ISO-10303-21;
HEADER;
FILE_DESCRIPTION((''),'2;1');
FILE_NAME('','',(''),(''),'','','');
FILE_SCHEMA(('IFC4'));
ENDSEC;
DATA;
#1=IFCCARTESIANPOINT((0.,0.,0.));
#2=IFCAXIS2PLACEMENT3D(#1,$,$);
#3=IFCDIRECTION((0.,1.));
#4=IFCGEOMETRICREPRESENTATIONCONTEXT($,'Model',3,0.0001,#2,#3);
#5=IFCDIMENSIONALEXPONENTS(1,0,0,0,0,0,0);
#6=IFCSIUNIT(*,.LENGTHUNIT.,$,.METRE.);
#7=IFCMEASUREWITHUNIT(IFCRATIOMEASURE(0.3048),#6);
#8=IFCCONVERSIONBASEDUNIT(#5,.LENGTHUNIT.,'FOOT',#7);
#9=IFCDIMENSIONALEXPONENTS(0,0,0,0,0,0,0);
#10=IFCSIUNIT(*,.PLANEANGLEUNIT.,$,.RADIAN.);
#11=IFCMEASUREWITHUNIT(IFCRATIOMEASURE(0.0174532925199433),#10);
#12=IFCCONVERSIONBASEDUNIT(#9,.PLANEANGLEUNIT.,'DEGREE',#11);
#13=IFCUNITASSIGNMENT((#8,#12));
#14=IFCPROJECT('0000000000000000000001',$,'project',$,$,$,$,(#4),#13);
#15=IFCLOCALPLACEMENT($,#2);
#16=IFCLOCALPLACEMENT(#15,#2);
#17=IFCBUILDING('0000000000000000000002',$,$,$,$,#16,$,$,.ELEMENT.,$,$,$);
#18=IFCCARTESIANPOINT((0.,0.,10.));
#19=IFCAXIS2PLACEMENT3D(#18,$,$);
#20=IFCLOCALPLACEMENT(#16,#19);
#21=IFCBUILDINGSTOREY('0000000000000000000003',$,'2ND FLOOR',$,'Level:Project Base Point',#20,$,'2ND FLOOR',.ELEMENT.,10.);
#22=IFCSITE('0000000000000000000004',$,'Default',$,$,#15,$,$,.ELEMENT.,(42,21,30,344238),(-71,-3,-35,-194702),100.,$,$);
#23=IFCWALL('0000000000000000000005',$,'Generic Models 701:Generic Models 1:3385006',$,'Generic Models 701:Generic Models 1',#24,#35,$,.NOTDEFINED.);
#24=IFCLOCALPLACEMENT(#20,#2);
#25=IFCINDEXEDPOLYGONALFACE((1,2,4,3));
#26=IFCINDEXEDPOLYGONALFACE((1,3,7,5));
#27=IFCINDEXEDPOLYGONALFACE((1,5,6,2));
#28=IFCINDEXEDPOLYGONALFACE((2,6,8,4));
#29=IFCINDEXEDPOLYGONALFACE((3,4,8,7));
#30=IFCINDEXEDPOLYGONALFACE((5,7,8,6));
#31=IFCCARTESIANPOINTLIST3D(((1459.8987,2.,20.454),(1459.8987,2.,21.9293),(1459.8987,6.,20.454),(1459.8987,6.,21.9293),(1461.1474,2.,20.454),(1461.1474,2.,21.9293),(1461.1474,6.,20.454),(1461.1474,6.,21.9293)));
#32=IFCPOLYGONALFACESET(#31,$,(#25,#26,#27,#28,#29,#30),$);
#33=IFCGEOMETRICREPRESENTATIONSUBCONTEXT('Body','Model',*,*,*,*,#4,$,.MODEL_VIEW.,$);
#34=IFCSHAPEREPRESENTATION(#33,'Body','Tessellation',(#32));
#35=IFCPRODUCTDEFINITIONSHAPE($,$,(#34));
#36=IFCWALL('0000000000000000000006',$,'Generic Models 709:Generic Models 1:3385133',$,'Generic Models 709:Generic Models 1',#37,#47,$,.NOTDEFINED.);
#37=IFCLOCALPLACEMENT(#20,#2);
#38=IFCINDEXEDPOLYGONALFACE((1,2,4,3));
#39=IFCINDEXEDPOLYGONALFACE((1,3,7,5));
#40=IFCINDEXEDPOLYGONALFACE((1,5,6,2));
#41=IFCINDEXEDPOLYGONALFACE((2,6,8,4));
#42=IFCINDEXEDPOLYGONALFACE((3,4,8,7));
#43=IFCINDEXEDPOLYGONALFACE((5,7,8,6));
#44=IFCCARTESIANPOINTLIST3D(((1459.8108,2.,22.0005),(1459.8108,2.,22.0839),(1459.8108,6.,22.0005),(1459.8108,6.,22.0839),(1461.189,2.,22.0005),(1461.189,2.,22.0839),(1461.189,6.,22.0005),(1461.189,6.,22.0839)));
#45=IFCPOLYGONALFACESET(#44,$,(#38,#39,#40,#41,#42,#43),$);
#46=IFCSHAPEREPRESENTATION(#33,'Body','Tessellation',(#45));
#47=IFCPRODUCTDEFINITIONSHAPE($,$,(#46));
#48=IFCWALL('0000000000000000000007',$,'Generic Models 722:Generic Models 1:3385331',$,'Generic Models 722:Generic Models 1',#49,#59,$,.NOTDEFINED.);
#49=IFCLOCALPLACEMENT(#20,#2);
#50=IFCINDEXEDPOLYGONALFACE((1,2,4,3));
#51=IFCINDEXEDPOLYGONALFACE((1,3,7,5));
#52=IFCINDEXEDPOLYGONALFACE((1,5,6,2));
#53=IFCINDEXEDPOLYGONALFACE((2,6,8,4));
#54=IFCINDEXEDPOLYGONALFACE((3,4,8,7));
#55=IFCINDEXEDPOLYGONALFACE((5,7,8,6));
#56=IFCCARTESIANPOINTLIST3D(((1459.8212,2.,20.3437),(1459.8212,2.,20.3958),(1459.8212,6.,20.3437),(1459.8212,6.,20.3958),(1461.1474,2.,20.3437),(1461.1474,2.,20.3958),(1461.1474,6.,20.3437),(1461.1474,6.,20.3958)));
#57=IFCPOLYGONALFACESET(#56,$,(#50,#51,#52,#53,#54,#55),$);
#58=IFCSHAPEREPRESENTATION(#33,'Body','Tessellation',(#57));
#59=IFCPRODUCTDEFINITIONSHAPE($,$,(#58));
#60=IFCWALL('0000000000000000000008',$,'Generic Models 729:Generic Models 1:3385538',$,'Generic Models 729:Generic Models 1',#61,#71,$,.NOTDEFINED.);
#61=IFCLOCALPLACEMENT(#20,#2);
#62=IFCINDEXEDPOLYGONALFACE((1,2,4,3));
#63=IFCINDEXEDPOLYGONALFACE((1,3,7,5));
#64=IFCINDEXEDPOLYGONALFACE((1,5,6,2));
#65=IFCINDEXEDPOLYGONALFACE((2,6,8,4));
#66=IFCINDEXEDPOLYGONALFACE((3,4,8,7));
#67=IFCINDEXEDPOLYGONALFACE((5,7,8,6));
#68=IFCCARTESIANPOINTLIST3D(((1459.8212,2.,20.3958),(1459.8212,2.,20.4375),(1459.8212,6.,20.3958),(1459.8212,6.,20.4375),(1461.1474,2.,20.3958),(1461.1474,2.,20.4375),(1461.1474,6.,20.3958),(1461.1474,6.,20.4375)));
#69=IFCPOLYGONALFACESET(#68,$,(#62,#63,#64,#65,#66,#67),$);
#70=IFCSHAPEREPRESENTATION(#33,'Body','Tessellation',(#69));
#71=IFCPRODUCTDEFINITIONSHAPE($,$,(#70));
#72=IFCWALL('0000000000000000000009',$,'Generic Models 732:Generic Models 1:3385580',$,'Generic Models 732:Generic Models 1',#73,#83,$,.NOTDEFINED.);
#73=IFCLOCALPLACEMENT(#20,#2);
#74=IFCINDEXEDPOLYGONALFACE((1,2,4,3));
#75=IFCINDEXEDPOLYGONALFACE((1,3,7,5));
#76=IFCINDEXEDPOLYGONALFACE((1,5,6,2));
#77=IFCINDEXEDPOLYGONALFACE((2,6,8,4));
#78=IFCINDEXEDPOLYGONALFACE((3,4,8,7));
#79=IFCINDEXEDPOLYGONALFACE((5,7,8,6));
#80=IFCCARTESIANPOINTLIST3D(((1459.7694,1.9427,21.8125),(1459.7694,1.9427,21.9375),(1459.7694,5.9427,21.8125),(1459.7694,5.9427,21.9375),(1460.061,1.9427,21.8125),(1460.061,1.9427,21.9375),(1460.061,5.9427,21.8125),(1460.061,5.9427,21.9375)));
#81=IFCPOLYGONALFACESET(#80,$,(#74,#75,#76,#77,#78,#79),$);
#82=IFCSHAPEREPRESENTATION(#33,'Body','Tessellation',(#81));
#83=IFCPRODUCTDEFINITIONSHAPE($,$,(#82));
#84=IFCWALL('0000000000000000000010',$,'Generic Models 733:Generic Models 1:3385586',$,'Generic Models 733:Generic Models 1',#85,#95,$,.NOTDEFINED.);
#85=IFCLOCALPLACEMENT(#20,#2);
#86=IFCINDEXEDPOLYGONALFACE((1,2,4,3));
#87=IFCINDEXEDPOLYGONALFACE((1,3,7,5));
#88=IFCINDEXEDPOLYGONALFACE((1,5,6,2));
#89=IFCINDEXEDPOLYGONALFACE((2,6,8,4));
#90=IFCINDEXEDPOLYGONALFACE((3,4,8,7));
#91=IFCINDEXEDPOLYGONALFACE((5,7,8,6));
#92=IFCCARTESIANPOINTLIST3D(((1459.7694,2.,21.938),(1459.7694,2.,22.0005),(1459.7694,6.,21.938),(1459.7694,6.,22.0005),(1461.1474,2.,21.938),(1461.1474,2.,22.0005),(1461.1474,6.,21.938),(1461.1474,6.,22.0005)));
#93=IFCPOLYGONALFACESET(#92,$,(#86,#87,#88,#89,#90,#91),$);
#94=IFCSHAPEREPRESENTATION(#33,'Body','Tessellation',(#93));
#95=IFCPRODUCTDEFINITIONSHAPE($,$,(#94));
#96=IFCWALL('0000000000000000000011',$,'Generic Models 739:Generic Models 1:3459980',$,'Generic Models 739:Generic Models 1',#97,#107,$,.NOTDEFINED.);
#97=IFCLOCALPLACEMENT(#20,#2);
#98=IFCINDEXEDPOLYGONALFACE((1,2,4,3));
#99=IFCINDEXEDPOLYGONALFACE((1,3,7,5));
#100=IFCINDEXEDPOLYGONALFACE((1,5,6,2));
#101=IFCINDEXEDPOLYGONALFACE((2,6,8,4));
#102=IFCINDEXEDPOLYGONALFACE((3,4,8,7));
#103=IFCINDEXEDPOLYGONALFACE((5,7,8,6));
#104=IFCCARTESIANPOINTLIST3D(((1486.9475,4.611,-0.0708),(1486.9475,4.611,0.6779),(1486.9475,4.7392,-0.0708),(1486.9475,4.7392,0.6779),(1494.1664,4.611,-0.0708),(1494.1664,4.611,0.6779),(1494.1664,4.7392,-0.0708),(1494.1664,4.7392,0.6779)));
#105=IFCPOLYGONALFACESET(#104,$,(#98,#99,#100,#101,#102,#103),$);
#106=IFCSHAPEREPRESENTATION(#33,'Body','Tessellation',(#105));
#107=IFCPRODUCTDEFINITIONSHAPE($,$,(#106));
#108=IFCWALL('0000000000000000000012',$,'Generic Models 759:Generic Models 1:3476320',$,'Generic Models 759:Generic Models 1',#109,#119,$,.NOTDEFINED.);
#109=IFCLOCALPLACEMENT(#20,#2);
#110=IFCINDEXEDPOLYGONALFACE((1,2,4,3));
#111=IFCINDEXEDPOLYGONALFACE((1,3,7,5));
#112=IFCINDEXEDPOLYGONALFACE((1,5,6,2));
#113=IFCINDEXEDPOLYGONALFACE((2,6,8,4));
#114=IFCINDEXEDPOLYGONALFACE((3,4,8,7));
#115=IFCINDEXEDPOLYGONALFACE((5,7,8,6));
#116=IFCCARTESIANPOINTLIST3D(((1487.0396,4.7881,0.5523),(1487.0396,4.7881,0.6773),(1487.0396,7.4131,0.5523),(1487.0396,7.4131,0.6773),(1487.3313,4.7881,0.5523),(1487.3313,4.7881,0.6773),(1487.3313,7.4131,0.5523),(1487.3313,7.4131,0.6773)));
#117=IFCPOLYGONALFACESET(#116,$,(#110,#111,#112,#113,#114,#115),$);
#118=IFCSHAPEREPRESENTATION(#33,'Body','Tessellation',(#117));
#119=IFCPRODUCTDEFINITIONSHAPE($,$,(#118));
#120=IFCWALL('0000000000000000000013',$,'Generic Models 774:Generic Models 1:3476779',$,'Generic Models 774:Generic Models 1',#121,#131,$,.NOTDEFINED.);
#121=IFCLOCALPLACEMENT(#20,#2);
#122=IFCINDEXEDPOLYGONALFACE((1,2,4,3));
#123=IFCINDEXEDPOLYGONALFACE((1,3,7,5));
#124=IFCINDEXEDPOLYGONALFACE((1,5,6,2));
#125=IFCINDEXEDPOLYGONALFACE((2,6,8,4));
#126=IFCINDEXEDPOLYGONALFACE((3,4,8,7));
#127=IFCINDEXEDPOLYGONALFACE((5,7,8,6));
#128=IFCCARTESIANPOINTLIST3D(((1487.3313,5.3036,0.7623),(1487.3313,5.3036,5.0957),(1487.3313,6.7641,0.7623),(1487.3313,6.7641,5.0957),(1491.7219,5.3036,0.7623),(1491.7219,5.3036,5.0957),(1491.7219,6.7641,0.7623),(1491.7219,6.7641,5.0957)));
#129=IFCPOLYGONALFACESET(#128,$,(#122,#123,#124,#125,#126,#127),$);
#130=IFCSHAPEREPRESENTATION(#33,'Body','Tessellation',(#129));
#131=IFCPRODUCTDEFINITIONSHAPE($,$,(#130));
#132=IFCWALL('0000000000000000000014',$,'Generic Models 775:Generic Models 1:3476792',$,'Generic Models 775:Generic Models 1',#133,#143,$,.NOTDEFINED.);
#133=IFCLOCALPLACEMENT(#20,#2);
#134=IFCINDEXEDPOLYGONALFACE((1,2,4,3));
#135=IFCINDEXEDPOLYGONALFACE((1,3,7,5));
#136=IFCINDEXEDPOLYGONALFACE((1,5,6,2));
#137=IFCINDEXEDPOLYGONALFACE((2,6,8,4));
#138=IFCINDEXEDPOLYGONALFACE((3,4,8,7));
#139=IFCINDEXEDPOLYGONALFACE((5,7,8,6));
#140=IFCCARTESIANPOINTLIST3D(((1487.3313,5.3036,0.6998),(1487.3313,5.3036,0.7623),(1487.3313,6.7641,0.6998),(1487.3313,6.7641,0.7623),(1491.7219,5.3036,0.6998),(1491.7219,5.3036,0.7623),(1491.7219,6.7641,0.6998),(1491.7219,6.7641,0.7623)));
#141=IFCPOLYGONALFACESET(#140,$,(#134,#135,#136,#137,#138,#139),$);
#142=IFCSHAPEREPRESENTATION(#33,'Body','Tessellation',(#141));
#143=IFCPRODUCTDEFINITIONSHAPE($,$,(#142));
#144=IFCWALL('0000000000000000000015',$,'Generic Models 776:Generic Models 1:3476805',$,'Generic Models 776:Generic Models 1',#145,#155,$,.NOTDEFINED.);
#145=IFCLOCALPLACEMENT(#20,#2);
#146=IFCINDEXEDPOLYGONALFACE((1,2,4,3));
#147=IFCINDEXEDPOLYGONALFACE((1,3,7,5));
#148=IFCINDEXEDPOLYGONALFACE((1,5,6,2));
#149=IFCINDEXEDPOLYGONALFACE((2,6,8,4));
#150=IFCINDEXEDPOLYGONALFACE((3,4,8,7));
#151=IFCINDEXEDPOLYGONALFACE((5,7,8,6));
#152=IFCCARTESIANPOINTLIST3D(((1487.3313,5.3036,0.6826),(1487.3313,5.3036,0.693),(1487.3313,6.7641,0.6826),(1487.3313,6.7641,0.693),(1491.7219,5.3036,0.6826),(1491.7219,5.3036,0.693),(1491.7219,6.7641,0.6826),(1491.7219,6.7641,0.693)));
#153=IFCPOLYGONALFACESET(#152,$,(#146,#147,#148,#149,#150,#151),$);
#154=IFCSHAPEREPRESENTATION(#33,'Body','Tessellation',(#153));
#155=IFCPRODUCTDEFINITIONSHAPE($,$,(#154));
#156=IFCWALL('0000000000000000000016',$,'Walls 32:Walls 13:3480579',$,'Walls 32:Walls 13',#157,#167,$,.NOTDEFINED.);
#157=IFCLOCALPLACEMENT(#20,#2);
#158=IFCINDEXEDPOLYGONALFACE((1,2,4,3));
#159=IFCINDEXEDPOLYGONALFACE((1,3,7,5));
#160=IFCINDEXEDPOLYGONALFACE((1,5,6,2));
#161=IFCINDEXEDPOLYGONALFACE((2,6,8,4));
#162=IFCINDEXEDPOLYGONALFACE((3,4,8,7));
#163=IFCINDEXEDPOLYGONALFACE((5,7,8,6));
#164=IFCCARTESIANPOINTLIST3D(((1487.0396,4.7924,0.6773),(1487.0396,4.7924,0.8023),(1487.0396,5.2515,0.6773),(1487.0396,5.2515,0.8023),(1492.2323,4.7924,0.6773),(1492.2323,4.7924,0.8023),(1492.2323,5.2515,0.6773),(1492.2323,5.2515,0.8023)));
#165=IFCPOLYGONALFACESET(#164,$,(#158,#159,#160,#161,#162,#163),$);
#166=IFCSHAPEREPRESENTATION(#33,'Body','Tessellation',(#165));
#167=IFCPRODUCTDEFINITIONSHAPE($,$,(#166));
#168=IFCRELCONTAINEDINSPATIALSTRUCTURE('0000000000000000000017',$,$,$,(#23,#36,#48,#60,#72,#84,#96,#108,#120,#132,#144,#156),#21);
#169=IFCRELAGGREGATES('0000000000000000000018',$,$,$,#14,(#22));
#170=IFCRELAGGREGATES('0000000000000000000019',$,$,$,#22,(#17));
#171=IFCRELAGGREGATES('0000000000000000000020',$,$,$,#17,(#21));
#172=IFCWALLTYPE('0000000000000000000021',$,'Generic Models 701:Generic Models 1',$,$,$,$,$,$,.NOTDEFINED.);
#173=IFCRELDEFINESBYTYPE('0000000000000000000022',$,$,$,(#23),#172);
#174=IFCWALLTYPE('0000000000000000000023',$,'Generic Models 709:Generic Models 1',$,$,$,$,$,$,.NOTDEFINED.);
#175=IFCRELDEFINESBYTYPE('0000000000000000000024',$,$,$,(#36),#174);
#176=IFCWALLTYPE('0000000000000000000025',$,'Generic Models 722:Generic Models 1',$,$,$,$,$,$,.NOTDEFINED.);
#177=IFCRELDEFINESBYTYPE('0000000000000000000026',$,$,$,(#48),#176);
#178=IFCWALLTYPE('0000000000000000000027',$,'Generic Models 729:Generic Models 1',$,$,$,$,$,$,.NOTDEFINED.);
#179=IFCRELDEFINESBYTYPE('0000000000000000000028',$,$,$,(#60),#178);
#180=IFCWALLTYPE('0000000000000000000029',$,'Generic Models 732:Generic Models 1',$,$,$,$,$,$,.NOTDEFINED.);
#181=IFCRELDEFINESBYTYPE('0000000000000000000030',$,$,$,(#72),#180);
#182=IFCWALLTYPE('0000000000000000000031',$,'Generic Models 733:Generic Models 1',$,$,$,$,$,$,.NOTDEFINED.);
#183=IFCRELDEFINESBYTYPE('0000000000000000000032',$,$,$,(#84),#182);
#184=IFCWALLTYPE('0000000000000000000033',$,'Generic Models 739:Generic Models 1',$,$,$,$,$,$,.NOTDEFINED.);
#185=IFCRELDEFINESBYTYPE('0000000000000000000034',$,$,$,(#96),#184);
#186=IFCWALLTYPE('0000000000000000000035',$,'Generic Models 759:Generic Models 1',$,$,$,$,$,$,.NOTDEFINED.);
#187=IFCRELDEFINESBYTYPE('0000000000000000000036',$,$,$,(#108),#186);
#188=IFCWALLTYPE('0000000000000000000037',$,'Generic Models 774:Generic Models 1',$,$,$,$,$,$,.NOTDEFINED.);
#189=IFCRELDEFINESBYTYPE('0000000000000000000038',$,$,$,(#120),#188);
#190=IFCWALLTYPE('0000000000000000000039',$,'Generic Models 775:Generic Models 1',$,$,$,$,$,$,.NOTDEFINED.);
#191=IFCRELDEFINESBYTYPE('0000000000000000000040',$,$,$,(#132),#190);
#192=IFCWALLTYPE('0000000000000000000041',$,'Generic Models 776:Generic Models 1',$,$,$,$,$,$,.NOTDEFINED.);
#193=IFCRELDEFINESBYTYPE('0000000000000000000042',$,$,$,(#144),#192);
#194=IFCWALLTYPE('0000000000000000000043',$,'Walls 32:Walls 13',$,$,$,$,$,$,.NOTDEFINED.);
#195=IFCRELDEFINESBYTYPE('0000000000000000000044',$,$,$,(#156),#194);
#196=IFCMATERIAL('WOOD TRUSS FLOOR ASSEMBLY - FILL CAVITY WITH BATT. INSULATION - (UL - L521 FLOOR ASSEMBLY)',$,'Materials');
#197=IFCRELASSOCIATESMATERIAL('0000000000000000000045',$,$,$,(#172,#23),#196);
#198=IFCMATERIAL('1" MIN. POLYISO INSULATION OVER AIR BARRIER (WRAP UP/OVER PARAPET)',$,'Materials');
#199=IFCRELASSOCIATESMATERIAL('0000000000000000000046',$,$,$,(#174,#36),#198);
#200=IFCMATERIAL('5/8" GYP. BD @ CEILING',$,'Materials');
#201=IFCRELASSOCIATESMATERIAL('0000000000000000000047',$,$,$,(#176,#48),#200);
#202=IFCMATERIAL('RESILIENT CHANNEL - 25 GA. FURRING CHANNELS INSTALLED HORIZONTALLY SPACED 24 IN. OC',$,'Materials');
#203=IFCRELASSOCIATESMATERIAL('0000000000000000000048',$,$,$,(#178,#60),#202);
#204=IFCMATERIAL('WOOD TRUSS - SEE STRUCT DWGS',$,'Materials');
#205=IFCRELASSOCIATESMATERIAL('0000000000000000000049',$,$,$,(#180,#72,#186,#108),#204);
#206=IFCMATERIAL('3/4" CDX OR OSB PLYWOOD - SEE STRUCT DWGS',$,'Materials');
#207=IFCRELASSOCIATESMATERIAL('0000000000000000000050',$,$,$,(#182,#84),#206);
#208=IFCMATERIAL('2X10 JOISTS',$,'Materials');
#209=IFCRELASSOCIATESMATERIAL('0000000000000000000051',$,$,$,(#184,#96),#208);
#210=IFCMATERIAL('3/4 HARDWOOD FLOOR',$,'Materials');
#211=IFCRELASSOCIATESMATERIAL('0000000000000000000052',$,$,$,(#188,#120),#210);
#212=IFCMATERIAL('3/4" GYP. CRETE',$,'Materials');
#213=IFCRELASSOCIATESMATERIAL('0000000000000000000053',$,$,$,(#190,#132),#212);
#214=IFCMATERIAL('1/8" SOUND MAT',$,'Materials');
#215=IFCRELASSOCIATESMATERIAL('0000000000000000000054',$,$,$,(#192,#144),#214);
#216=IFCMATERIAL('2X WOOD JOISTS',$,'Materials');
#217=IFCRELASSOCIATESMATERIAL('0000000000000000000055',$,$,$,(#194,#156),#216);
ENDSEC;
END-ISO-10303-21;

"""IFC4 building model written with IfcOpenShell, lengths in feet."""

from ifc_helpers import new_model, entity, si_unit, converted_unit, direction, frame, frame_2d, origin, origin_2d_with_axis, place, context, subcontext, project, spatial, rectangle, extrude, material, type_object, element, save


model = new_model("IFC4")

# Units and contexts
model_context = context("Model", 3, precision=0.0001, world=origin(), true_north=direction((0.0, 1.0)))
body_context = subcontext(model_context, "Body", "Model", "MODEL_VIEW")
ifc_project = project(units=[converted_unit("LENGTHUNIT", "FOOT", entity("IfcRatioMeasure", 0.3048), si_unit("LENGTHUNIT", "METRE"), dimensions=[1, 0, 0, 0, 0, 0, 0]), converted_unit("PLANEANGLEUNIT", "DEGREE", entity("IfcRatioMeasure", 0.0174532925199433), si_unit("PLANEANGLEUNIT", "RADIAN"), dimensions=[0, 0, 0, 0, 0, 0, 0])], contexts=[model_context])

# Site, building, storey
site_placement = place(None, origin())
site = spatial("IfcSite", under=ifc_project, at=site_placement, Name="Default", CompositionType="ELEMENT", RefLatitude=(42, 21, 30, 344238), RefLongitude=(-71, -3, -35, -194702), RefElevation=100.0)
building_placement = place(site_placement, origin())
building = spatial("IfcBuilding", under=site, at=building_placement, CompositionType="ELEMENT")
storey_placement = place(building_placement, frame((0.0, 0.0, 10.0)))
storey = spatial("IfcBuildingStorey", under=building, at=storey_placement, Name="2ND FLOOR", ObjectType="Level:Project Base Point", LongName="2ND FLOOR", CompositionType="ELEMENT", Elevation=10.0)

# Walls
ifc_material_1 = material(Name="WOOD TRUSS FLOOR ASSEMBLY - FILL CAVITY WITH BATT. INSULATION - (UL - L521 FLOOR ASSEMBLY)", Category="Materials")
wall_type_1 = type_object("IfcWallType", Name="Generic Models 701:Generic Models 1", PredefinedType="NOTDEFINED", material=ifc_material_1)
wall_1_placement = place(storey_placement, frame((1459.8987, 2.0, 20.454), z_axis=(0.0, 0.0, 1.0), x_axis=(0.0, 1.0, 0.0)))
element("IfcWall", 1, at=wall_1_placement, inside=storey, type_object=wall_type_1, material=ifc_material_1, Name="Generic Models 701:Generic Models 1:3385006", ObjectType="Generic Models 701:Generic Models 1", PredefinedType="NOTDEFINED", context=body_context, shape_type="SweptSolid", body=[
    extrude(rectangle(XDim=4.0, YDim=1.2486, at=frame_2d((0.0, 0.0), x_axis=(1.0, 0.0))), frame((2.0, -0.6243, 0.0)), (0.0, 0.0, 1.0), 1.4753),
])
ifc_material_2 = material(Name="1\" MIN. POLYISO INSULATION OVER AIR BARRIER (WRAP UP/OVER PARAPET)", Category="Materials")
wall_type_2 = type_object("IfcWallType", Name="Generic Models 709:Generic Models 1", PredefinedType="NOTDEFINED", material=ifc_material_2)
wall_2_placement = place(storey_placement, frame((1459.8108, 2.0, 22.0005), z_axis=(0.0, 0.0, 1.0), x_axis=(0.0, 1.0, 0.0)))
element("IfcWall", 2, at=wall_2_placement, inside=storey, type_object=wall_type_2, material=ifc_material_2, Name="Generic Models 709:Generic Models 1:3385133", ObjectType="Generic Models 709:Generic Models 1", PredefinedType="NOTDEFINED", context=body_context, shape_type="SweptSolid", body=[
    extrude(rectangle(XDim=4.0, YDim=1.3782, at=frame_2d((0.0, 0.0), x_axis=(1.0, 0.0))), frame((2.0, -0.6891, 0.0)), (0.0, 0.0, 1.0), 0.0833),
])
ifc_material_3 = material(Name="5/8\" GYP. BD @ CEILING", Category="Materials")
wall_type_3 = type_object("IfcWallType", Name="Generic Models 722:Generic Models 1", PredefinedType="NOTDEFINED", material=ifc_material_3)
wall_3_placement = place(storey_placement, frame((1459.8212, 2.0, 20.3437), z_axis=(0.0, 0.0, 1.0), x_axis=(0.0, 1.0, 0.0)))
element("IfcWall", 3, at=wall_3_placement, inside=storey, type_object=wall_type_3, material=ifc_material_3, Name="Generic Models 722:Generic Models 1:3385331", ObjectType="Generic Models 722:Generic Models 1", PredefinedType="NOTDEFINED", context=body_context, shape_type="SweptSolid", body=[
    extrude(rectangle(XDim=4.0, YDim=1.3261, at=frame_2d((0.0, 0.0), x_axis=(1.0, 0.0))), frame((2.0, -0.6631, 0.0)), (0.0, 0.0, 1.0), 0.0521),
])
ifc_material_4 = material(Name="RESILIENT CHANNEL - 25 GA. FURRING CHANNELS INSTALLED HORIZONTALLY SPACED 24 IN. OC", Category="Materials")
wall_type_4 = type_object("IfcWallType", Name="Generic Models 729:Generic Models 1", PredefinedType="NOTDEFINED", material=ifc_material_4)
wall_4_placement = place(storey_placement, frame((1459.8212, 2.0, 20.3958), z_axis=(0.0, 0.0, 1.0), x_axis=(0.0, 1.0, 0.0)))
element("IfcWall", 4, at=wall_4_placement, inside=storey, type_object=wall_type_4, material=ifc_material_4, Name="Generic Models 729:Generic Models 1:3385538", ObjectType="Generic Models 729:Generic Models 1", PredefinedType="NOTDEFINED", context=body_context, shape_type="SweptSolid", body=[
    extrude(rectangle(XDim=4.0, YDim=1.3261, at=frame_2d((0.0, 0.0), x_axis=(1.0, 0.0))), frame((2.0, -0.6631, 0.0)), (0.0, 0.0, 1.0), 0.0417),
])
ifc_material_5 = material(Name="WOOD TRUSS - SEE STRUCT DWGS", Category="Materials")
wall_type_5 = type_object("IfcWallType", Name="Generic Models 732:Generic Models 1", PredefinedType="NOTDEFINED", material=ifc_material_5)
wall_5_placement = place(storey_placement, frame((1459.7694, 1.9427, 21.8125), z_axis=(0.0, 0.0, 1.0), x_axis=(0.0, 1.0, 0.0)))
element("IfcWall", 5, at=wall_5_placement, inside=storey, type_object=wall_type_5, material=ifc_material_5, Name="Generic Models 732:Generic Models 1:3385580", ObjectType="Generic Models 732:Generic Models 1", PredefinedType="NOTDEFINED", context=body_context, shape_type="SweptSolid", body=[
    extrude(rectangle(XDim=4.0, YDim=0.2917, at=frame_2d((0.0, 0.0), x_axis=(1.0, 0.0))), frame((2.0, -0.1458, 0.0)), (0.0, 0.0, 1.0), 0.125),
])
ifc_material_6 = material(Name="3/4\" CDX OR OSB PLYWOOD - SEE STRUCT DWGS", Category="Materials")
wall_type_6 = type_object("IfcWallType", Name="Generic Models 733:Generic Models 1", PredefinedType="NOTDEFINED", material=ifc_material_6)
wall_6_placement = place(storey_placement, frame((1459.7694, 2.0, 21.938), z_axis=(0.0, 0.0, 1.0), x_axis=(0.0, 1.0, 0.0)))
element("IfcWall", 6, at=wall_6_placement, inside=storey, type_object=wall_type_6, material=ifc_material_6, Name="Generic Models 733:Generic Models 1:3385586", ObjectType="Generic Models 733:Generic Models 1", PredefinedType="NOTDEFINED", context=body_context, shape_type="SweptSolid", body=[
    extrude(rectangle(XDim=4.0, YDim=1.378, at=frame_2d((0.0, 0.0), x_axis=(1.0, 0.0))), frame((2.0, -0.689, 0.0)), (0.0, 0.0, 1.0), 0.0625),
])
ifc_material_7 = material(Name="2X10 JOISTS", Category="Materials")
wall_type_7 = type_object("IfcWallType", Name="Generic Models 739:Generic Models 1", PredefinedType="NOTDEFINED", material=ifc_material_7)
wall_7_placement = place(storey_placement, frame((1486.9475, 4.611, -0.0708)))
element("IfcWall", 7, at=wall_7_placement, inside=storey, type_object=wall_type_7, material=ifc_material_7, Name="Generic Models 739:Generic Models 1:3459980", ObjectType="Generic Models 739:Generic Models 1", PredefinedType="NOTDEFINED", context=body_context, shape_type="SweptSolid", body=[
    extrude(rectangle(XDim=0.1282, YDim=7.219, at=frame_2d((0.0, 0.0), x_axis=(1.0, 0.0))), frame((3.6095, 0.0641, 0.0), z_axis=(0.0, 0.0, 1.0), x_axis=(0.0, 1.0, 0.0)), (0.0, 0.0, 1.0), 0.7486),
])
wall_type_8 = type_object("IfcWallType", Name="Generic Models 759:Generic Models 1", PredefinedType="NOTDEFINED", material=ifc_material_5)
wall_8_placement = place(storey_placement, frame((1487.0396, 4.7881, 0.5523), z_axis=(0.0, 0.0, 1.0), x_axis=(0.0, 1.0, 0.0)))
element("IfcWall", 8, at=wall_8_placement, inside=storey, type_object=wall_type_8, material=ifc_material_5, Name="Generic Models 759:Generic Models 1:3476320", ObjectType="Generic Models 759:Generic Models 1", PredefinedType="NOTDEFINED", context=body_context, shape_type="SweptSolid", body=[
    extrude(rectangle(XDim=2.625, YDim=0.2917, at=frame_2d((0.0, 0.0), x_axis=(1.0, 0.0))), frame((1.3125, -0.1458, 0.0)), (0.0, 0.0, 1.0), 0.125),
])
ifc_material_8 = material(Name="3/4 HARDWOOD FLOOR", Category="Materials")
wall_type_9 = type_object("IfcWallType", Name="Generic Models 774:Generic Models 1", PredefinedType="NOTDEFINED", material=ifc_material_8)
wall_9_placement = place(storey_placement, frame((1487.3313, 5.3036, 0.7623)))
element("IfcWall", 9, at=wall_9_placement, inside=storey, type_object=wall_type_9, material=ifc_material_8, Name="Generic Models 774:Generic Models 1:3476779", ObjectType="Generic Models 774:Generic Models 1", PredefinedType="NOTDEFINED", context=body_context, shape_type="SweptSolid", body=[
    extrude(rectangle(XDim=1.4605, YDim=4.3906, at=frame_2d((0.0, 0.0), x_axis=(1.0, 0.0))), frame((2.1953, 0.7302, 0.0), z_axis=(0.0, 0.0, 1.0), x_axis=(0.0, 1.0, 0.0)), (0.0, 0.0, 1.0), 4.3334),
])
ifc_material_9 = material(Name="3/4\" GYP. CRETE", Category="Materials")
wall_type_10 = type_object("IfcWallType", Name="Generic Models 775:Generic Models 1", PredefinedType="NOTDEFINED", material=ifc_material_9)
wall_10_placement = place(storey_placement, frame((1487.3313, 5.3036, 0.6998)))
element("IfcWall", 10, at=wall_10_placement, inside=storey, type_object=wall_type_10, material=ifc_material_9, Name="Generic Models 775:Generic Models 1:3476792", ObjectType="Generic Models 775:Generic Models 1", PredefinedType="NOTDEFINED", context=body_context, shape_type="SweptSolid", body=[
    extrude(rectangle(XDim=1.4605, YDim=4.3906, at=frame_2d((0.0, 0.0), x_axis=(1.0, 0.0))), frame((2.1953, 0.7302, 0.0), z_axis=(0.0, 0.0, 1.0), x_axis=(0.0, 1.0, 0.0)), (0.0, 0.0, 1.0), 0.0625),
])
ifc_material_10 = material(Name="1/8\" SOUND MAT", Category="Materials")
wall_type_11 = type_object("IfcWallType", Name="Generic Models 776:Generic Models 1", PredefinedType="NOTDEFINED", material=ifc_material_10)
wall_11_placement = place(storey_placement, frame((1487.3313, 5.3036, 0.6826)))
element("IfcWall", 11, at=wall_11_placement, inside=storey, type_object=wall_type_11, material=ifc_material_10, Name="Generic Models 776:Generic Models 1:3476805", ObjectType="Generic Models 776:Generic Models 1", PredefinedType="NOTDEFINED", context=body_context, shape_type="SweptSolid", body=[
    extrude(rectangle(XDim=1.4605, YDim=4.3906, at=frame_2d((0.0, 0.0), x_axis=(1.0, 0.0))), frame((2.1953, 0.7302, 0.0), z_axis=(0.0, 0.0, 1.0), x_axis=(0.0, 1.0, 0.0)), (0.0, 0.0, 1.0), 0.0104),
])
ifc_material_11 = material(Name="2X WOOD JOISTS", Category="Materials")
wall_type_12 = type_object("IfcWallType", Name="Walls 32:Walls 13", PredefinedType="NOTDEFINED", material=ifc_material_11)
wall_12_placement = place(storey_placement, frame((1487.0396, 4.7924, 0.6773)))
element("IfcWall", 12, at=wall_12_placement, inside=storey, type_object=wall_type_12, material=ifc_material_11, Name="Walls 32:Walls 13:3480579", ObjectType="Walls 32:Walls 13", PredefinedType="NOTDEFINED", context=body_context, shape_type="SweptSolid", body=[
    extrude(rectangle(XDim=0.4592, YDim=5.1927, at=origin_2d_with_axis()), frame((2.5964, 0.2296, 0.0), z_axis=(0.0, 0.0, 1.0), x_axis=(0.0, 1.0, 0.0)), (0.0, 0.0, 1.0), 0.125),
])

save(model, "model.ifc")
